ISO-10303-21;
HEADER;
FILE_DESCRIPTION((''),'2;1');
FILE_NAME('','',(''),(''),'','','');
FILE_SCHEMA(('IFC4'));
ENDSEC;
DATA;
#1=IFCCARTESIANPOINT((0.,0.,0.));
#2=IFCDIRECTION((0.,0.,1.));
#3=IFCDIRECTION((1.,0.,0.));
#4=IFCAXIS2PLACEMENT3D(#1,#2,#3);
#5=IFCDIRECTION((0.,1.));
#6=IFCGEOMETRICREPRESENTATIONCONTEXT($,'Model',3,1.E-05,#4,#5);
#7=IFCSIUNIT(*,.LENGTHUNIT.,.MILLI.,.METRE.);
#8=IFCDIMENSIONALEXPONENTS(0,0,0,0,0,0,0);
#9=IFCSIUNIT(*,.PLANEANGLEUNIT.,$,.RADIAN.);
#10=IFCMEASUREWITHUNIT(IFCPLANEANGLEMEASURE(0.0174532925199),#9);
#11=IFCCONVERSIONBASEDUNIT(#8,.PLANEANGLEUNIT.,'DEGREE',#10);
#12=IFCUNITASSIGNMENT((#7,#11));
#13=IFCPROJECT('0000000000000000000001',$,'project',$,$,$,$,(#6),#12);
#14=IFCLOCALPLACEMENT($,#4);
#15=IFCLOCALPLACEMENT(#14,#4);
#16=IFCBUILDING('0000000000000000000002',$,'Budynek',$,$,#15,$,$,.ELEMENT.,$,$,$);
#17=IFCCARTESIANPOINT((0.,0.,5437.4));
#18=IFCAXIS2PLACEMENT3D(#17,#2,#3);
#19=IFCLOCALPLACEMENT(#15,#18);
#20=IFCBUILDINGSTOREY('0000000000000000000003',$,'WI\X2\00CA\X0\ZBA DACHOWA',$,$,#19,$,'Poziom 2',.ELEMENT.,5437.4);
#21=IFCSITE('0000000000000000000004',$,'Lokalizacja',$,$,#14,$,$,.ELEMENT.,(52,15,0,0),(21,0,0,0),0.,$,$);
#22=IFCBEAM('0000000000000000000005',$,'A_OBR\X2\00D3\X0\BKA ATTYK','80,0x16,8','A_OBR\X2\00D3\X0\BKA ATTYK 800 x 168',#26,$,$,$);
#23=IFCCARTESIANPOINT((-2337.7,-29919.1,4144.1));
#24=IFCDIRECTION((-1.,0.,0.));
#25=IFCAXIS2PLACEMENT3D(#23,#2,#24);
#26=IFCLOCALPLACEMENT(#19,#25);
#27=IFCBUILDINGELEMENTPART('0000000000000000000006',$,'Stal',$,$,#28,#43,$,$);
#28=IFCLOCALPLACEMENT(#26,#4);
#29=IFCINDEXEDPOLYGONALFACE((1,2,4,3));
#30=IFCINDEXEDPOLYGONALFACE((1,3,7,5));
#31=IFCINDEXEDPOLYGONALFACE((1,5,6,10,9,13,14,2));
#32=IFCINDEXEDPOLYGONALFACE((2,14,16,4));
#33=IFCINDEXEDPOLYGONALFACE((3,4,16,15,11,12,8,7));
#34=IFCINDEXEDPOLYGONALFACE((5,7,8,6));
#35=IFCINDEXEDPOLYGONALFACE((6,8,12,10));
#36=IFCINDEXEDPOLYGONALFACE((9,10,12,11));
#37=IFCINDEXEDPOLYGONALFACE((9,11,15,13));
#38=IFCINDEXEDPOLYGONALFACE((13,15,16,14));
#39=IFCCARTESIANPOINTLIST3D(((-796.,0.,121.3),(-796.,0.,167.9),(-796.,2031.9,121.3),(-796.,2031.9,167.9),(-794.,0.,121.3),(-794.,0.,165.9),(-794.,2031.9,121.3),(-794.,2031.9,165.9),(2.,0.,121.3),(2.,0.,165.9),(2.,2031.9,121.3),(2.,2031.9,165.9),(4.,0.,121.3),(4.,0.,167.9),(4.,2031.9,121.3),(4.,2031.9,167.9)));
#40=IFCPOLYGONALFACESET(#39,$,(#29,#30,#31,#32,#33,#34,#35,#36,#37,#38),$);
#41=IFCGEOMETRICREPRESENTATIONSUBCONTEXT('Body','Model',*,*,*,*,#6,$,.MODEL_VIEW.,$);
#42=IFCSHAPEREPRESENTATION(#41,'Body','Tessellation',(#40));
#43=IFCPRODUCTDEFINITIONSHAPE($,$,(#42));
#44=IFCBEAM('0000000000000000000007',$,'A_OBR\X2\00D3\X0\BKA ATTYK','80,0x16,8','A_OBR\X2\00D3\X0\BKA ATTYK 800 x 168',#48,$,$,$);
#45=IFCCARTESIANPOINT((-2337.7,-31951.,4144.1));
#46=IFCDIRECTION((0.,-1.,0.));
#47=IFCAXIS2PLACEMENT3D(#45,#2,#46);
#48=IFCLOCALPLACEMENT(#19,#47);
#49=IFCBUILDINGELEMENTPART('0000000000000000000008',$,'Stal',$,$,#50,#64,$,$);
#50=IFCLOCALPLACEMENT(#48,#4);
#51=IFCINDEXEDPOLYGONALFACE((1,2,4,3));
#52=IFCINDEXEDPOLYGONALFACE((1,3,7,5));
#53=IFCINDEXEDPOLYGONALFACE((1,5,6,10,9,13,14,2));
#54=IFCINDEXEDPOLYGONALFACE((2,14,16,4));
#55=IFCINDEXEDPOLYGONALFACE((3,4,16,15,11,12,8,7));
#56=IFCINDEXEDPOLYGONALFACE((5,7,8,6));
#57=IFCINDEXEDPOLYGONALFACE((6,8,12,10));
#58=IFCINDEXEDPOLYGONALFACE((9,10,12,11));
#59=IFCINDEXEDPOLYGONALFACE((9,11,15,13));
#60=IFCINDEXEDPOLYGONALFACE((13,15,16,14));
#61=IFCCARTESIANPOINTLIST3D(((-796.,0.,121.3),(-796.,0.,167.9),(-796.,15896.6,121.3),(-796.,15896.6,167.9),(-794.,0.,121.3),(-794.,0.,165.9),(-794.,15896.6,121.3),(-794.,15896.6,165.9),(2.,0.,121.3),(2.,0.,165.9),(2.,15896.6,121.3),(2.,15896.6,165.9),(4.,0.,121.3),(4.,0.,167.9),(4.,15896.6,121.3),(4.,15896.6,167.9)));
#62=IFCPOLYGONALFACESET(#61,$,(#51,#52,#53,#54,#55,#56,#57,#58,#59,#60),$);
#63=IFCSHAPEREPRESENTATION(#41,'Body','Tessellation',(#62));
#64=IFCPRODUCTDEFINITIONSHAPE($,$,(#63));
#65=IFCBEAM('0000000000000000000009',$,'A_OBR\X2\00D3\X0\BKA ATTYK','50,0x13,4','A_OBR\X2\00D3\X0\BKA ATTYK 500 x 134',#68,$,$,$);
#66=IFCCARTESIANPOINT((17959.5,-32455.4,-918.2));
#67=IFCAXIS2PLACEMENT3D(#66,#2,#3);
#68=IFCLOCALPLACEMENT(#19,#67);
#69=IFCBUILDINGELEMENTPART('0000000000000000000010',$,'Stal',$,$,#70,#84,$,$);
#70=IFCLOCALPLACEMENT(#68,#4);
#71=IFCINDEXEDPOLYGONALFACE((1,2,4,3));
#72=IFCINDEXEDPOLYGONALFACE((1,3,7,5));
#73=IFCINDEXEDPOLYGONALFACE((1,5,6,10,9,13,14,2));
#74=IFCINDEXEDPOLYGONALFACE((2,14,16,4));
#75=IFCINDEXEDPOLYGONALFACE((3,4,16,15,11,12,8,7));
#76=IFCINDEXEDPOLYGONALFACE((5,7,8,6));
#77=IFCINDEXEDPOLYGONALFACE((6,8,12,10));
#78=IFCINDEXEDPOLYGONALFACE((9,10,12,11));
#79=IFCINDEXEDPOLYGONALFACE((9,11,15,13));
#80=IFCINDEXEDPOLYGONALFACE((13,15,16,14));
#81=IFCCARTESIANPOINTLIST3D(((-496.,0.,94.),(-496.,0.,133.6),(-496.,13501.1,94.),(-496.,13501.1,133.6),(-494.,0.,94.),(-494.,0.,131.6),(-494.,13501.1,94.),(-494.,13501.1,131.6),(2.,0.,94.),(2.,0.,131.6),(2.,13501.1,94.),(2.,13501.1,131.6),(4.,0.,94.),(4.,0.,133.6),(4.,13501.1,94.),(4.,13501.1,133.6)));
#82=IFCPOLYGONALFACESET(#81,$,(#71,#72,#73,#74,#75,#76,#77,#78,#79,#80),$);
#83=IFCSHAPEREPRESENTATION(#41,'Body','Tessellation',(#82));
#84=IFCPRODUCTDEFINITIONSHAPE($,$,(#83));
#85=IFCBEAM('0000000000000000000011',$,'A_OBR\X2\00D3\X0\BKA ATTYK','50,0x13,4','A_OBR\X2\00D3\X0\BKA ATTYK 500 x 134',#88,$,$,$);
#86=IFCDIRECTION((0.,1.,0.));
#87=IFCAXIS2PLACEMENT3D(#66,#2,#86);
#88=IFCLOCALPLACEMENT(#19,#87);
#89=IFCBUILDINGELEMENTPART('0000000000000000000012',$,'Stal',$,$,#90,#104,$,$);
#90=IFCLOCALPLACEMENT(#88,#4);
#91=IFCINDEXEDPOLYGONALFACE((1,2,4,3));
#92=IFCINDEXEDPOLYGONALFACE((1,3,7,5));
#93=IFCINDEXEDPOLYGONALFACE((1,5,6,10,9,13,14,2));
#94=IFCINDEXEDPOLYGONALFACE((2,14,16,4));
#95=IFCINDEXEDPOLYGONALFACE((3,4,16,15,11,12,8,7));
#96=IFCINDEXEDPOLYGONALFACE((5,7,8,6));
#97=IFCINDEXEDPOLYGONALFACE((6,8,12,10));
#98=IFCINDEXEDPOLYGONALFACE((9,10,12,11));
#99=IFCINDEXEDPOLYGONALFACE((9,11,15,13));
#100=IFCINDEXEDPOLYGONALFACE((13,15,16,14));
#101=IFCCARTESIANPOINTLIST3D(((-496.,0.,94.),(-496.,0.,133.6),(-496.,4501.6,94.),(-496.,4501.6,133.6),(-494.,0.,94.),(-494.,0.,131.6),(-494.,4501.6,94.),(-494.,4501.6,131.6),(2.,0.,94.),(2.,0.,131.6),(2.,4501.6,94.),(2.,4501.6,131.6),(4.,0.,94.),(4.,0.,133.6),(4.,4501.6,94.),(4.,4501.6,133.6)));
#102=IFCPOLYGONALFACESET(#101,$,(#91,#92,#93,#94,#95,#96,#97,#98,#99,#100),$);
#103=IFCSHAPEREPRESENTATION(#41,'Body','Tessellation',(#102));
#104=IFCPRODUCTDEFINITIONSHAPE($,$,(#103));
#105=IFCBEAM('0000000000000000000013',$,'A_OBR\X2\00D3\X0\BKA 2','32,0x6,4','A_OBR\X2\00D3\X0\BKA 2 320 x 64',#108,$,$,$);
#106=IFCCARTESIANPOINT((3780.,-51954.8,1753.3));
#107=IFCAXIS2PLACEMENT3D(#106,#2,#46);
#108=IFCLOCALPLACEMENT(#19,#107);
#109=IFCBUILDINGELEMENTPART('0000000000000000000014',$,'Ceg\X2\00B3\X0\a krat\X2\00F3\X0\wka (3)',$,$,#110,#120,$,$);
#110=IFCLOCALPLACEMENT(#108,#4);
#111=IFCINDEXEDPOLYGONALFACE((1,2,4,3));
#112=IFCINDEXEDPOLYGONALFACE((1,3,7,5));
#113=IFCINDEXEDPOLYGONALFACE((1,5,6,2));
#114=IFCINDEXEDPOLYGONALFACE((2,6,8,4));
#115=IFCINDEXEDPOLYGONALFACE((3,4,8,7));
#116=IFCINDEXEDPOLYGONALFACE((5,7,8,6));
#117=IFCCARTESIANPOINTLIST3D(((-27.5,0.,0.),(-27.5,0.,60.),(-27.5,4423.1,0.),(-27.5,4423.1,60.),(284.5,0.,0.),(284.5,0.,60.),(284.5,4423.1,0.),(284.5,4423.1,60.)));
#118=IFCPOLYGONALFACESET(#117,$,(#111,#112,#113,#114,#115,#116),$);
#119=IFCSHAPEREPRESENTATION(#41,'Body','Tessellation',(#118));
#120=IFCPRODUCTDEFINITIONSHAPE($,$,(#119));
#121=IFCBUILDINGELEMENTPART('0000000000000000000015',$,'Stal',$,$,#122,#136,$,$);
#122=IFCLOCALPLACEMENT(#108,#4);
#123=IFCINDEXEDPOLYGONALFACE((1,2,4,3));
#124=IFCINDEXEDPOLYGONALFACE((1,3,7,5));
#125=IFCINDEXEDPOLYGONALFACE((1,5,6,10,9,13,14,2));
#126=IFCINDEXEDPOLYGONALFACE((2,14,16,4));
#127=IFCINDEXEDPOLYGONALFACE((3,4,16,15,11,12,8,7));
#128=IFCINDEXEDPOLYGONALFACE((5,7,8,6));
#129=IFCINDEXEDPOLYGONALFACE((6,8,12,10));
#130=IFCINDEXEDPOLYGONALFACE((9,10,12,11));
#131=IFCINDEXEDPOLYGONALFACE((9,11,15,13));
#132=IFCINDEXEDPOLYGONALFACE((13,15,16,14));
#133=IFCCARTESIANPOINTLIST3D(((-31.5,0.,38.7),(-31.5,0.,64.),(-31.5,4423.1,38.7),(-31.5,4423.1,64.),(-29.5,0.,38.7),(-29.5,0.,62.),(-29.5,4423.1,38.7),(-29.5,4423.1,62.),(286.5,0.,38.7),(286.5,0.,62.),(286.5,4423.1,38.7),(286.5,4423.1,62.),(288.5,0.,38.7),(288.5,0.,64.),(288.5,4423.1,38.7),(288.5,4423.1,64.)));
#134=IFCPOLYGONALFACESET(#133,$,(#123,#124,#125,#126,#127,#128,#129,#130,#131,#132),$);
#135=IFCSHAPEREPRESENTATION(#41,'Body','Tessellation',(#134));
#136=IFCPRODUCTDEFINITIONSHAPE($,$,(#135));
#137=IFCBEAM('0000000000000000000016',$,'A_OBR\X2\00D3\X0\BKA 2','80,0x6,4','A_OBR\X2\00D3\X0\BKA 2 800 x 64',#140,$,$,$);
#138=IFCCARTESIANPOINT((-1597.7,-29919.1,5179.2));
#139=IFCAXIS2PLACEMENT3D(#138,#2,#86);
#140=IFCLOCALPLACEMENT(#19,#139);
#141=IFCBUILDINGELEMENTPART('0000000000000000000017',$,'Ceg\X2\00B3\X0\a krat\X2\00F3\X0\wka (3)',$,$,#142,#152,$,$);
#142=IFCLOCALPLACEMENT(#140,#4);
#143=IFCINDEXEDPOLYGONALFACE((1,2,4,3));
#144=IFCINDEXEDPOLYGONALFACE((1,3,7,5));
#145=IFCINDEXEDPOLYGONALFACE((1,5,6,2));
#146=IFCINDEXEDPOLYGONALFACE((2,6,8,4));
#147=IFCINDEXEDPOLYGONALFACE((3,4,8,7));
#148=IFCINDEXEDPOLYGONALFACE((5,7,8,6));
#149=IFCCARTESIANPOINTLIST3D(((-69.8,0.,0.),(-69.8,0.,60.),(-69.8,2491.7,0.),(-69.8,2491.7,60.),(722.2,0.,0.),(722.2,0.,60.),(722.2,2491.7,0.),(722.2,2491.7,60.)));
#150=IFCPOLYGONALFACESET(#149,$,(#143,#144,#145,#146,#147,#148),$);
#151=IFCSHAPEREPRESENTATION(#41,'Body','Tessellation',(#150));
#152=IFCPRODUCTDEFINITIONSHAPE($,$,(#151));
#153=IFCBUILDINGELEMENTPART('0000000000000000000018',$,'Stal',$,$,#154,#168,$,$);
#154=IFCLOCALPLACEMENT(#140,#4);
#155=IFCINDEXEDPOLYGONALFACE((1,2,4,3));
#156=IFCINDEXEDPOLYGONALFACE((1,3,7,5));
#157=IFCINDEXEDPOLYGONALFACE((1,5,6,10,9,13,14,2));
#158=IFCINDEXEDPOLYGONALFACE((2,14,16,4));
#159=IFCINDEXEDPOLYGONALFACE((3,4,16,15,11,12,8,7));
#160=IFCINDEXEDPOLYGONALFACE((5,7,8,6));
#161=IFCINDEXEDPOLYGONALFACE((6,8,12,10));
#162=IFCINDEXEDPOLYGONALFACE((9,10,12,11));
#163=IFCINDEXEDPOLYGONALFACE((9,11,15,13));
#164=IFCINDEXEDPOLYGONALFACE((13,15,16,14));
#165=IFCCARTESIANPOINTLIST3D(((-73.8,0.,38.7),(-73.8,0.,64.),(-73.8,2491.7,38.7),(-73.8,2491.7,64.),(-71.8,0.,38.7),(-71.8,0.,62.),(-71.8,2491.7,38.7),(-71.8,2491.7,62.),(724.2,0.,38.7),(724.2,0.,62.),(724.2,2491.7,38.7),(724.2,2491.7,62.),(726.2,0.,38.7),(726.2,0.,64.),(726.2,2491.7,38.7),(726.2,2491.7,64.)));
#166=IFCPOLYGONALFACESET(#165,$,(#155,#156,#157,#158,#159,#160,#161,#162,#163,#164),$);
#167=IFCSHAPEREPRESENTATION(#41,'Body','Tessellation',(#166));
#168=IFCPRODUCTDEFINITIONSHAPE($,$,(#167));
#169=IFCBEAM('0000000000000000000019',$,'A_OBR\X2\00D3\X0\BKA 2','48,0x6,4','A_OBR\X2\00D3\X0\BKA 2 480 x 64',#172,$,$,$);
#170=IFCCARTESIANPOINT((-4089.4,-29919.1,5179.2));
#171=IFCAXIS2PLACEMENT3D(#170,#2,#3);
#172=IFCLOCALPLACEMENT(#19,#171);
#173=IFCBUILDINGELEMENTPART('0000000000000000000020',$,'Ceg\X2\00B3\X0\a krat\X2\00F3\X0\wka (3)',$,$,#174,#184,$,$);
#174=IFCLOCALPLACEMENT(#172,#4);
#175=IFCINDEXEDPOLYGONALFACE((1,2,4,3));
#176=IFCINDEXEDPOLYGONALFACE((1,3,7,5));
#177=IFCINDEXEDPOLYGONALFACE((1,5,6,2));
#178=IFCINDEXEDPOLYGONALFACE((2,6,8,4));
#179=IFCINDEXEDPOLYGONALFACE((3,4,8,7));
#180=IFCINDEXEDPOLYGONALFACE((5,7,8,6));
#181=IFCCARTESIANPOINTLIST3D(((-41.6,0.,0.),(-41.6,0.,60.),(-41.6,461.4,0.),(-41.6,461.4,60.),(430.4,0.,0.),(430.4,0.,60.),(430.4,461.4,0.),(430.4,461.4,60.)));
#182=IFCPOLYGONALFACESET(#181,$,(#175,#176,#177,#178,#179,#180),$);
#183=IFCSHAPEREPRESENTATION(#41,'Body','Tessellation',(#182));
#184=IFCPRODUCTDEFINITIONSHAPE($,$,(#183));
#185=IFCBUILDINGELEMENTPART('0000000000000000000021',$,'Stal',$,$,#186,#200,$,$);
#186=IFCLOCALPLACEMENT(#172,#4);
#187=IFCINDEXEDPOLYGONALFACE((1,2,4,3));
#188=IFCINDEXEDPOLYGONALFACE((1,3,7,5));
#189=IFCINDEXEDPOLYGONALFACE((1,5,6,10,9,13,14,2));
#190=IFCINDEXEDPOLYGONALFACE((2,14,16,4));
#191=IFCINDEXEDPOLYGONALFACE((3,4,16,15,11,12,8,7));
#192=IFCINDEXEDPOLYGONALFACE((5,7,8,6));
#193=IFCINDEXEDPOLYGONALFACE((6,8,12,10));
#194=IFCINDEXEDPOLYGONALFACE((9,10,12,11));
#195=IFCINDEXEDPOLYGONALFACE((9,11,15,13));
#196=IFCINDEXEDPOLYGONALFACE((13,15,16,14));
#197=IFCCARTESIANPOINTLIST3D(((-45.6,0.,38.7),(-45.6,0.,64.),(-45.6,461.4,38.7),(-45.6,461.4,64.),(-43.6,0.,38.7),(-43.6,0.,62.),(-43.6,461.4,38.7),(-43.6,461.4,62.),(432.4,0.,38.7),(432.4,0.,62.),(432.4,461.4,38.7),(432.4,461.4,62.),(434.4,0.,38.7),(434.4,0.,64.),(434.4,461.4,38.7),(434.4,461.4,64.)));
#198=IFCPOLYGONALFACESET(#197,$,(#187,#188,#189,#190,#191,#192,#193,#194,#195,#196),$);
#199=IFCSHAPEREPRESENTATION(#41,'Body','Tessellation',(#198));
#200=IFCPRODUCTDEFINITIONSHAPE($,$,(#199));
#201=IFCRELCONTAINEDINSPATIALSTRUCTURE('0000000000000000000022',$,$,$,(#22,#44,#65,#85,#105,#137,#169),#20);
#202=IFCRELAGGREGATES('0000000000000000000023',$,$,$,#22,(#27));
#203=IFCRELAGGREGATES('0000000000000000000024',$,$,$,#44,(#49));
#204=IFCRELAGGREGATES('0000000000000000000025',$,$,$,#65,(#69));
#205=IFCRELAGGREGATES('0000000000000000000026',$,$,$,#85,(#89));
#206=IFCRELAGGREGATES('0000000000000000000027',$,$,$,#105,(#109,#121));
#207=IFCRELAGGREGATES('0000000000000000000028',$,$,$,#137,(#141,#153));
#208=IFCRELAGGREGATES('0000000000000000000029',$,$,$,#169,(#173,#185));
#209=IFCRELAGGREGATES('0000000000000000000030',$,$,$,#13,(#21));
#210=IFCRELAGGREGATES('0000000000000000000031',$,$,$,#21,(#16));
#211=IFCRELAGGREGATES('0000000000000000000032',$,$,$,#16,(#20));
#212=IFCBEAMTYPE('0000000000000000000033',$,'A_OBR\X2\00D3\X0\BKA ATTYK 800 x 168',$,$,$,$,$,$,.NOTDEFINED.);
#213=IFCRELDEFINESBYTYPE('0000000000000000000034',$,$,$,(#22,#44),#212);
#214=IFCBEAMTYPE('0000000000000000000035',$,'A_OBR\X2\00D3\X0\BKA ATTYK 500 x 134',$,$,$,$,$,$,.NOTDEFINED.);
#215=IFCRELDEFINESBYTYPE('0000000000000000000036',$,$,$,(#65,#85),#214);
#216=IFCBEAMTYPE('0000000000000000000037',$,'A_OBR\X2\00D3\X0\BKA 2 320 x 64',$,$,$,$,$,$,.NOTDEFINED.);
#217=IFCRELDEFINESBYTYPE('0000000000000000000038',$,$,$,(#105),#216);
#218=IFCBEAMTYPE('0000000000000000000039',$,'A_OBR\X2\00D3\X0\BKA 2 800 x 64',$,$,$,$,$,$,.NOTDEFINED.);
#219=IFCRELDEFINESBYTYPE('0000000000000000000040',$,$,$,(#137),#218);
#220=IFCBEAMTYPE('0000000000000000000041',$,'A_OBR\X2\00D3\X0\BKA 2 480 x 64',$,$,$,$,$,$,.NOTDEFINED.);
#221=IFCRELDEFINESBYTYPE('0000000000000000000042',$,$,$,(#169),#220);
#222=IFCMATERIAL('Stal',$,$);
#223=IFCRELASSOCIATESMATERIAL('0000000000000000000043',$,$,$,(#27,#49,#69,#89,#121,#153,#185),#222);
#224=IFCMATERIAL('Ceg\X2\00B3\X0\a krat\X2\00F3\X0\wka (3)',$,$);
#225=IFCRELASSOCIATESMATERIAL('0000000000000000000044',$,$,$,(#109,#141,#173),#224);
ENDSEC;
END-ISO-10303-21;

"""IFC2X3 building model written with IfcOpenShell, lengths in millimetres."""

from ifc_helpers import new_model, entity, si_unit, converted_unit, direction, frame, origin_with_axes, place, context, subcontext, project, spatial, polyline, outline, extrude, material, type_object, element, aggregate, save


model = new_model("IFC2X3")

# Units and contexts
model_context = context("Model", 3, precision=1e-05, world=origin_with_axes(), true_north=direction((0.0, 1.0)))
body_context = subcontext(model_context, "Body", "Model", "MODEL_VIEW")
ifc_project = project(units=[si_unit("LENGTHUNIT", "METRE", prefix="MILLI"), converted_unit("PLANEANGLEUNIT", "DEGREE", entity("IfcPlaneAngleMeasure", 0.0174532925199), si_unit("PLANEANGLEUNIT", "RADIAN"), dimensions=[0, 0, 0, 0, 0, 0, 0])], contexts=[model_context])

# Site, building, storey
site_placement = place(None, origin_with_axes())
site = spatial("IfcSite", under=ifc_project, at=site_placement, Name="Lokalizacja", CompositionType="ELEMENT", RefLatitude=(52, 15, 0, 0), RefLongitude=(21, 0, 0, 0), RefElevation=0.0)
building_placement = place(site_placement, origin_with_axes())
building = spatial("IfcBuilding", under=site, at=building_placement, Name="Budynek", CompositionType="ELEMENT")
storey_placement = place(building_placement, frame((0.0, 0.0, 5437.4), z_axis=(0.0, 0.0, 1.0), x_axis=(1.0, 0.0, 0.0)))
storey = spatial("IfcBuildingStorey", under=building, at=storey_placement, Name="WIÊZBA DACHOWA", LongName="Poziom 2", CompositionType="ELEMENT", Elevation=5437.4)

# Shared definitions
ifc_material_1 = material(Name="Ceg³a kratówka (3)")

# Beams, building element parts
beam_type_1 = type_object("IfcBeamType", Name="A_OBRÓBKA ATTYK 800 x 168", PredefinedType="NOTDEFINED")
beam_1_placement = place(storey_placement, frame((-2337.7, -29919.1, 4144.1), z_axis=(0.0, 0.0, 1.0), x_axis=(-1.0, 0.0, 0.0)))
beam_1 = element("IfcBeam", 1, at=beam_1_placement, inside=storey, type_object=beam_type_1, Name="A_OBRÓBKA ATTYK", Description="80,0x16,8", ObjectType="A_OBRÓBKA ATTYK 800 x 168")
ifc_material_2 = material(Name="Stal")
building_element_part_1_placement = place(beam_1_placement, origin_with_axes())
building_element_part_1 = element("IfcBuildingElementPart", 2, at=building_element_part_1_placement, material=ifc_material_2, Name="Stal", context=body_context, shape_type="SweptSolid", body=[
    extrude(outline(polyline([(-796.0, 167.9), (-796.0, 121.3), (-794.0, 121.3), (-794.0, 165.9), (2.0, 165.9), (2.0, 121.3), (4.0, 121.3), (4.0, 167.9), (-796.0, 167.9)])), frame((0.0, 2031.9, 0.0), z_axis=(0.0, -1.0, 0.0), x_axis=(1.0, 0.0, 0.0)), (0.0, 0.0, 1.0), 2031.9),
])
aggregate(beam_1, [building_element_part_1])
beam_2_placement = place(storey_placement, frame((-2337.7, -31951.0, 4144.1), z_axis=(0.0, 0.0, 1.0), x_axis=(0.0, -1.0, 0.0)))
beam_2 = element("IfcBeam", 3, at=beam_2_placement, inside=storey, type_object=beam_type_1, Name="A_OBRÓBKA ATTYK", Description="80,0x16,8", ObjectType="A_OBRÓBKA ATTYK 800 x 168")
building_element_part_2_placement = place(beam_2_placement, origin_with_axes())
building_element_part_2 = element("IfcBuildingElementPart", 4, at=building_element_part_2_placement, material=ifc_material_2, Name="Stal", context=body_context, shape_type="SweptSolid", body=[
    extrude(outline(polyline([(-796.0, 167.9), (-796.0, 121.3), (-794.0, 121.3), (-794.0, 165.9), (2.0, 165.9), (2.0, 121.3), (4.0, 121.3), (4.0, 167.9), (-796.0, 167.9)])), frame((0.0, 15896.6, 0.0), z_axis=(0.0, -1.0, 0.0), x_axis=(1.0, 0.0, 0.0)), (0.0, 0.0, 1.0), 15896.6),
])
aggregate(beam_2, [building_element_part_2])
beam_type_2 = type_object("IfcBeamType", Name="A_OBRÓBKA ATTYK 500 x 134", PredefinedType="NOTDEFINED")
beam_3_placement = place(storey_placement, frame((17959.5, -32455.4, -918.2), z_axis=(0.0, 0.0, 1.0), x_axis=(1.0, 0.0, 0.0)))
beam_3 = element("IfcBeam", 5, at=beam_3_placement, inside=storey, type_object=beam_type_2, Name="A_OBRÓBKA ATTYK", Description="50,0x13,4", ObjectType="A_OBRÓBKA ATTYK 500 x 134")
building_element_part_3_placement = place(beam_3_placement, origin_with_axes())
building_element_part_3 = element("IfcBuildingElementPart", 6, at=building_element_part_3_placement, material=ifc_material_2, Name="Stal", context=body_context, shape_type="SweptSolid", body=[
    extrude(outline(polyline([(-496.0, 133.6), (-496.0, 94.0), (-494.0, 94.0), (-494.0, 131.6), (2.0, 131.6), (2.0, 94.0), (4.0, 94.0), (4.0, 133.6), (-496.0, 133.6)])), frame((0.0, 13501.1, 0.0), z_axis=(0.0, -1.0, 0.0), x_axis=(1.0, 0.0, 0.0)), (0.0, 0.0, 1.0), 13501.1),
])
aggregate(beam_3, [building_element_part_3])
beam_4_placement = place(storey_placement, frame((17959.5, -32455.4, -918.2), z_axis=(0.0, 0.0, 1.0), x_axis=(0.0, 1.0, 0.0)))
beam_4 = element("IfcBeam", 7, at=beam_4_placement, inside=storey, type_object=beam_type_2, Name="A_OBRÓBKA ATTYK", Description="50,0x13,4", ObjectType="A_OBRÓBKA ATTYK 500 x 134")
building_element_part_4_placement = place(beam_4_placement, origin_with_axes())
building_element_part_4 = element("IfcBuildingElementPart", 8, at=building_element_part_4_placement, material=ifc_material_2, Name="Stal", context=body_context, shape_type="SweptSolid", body=[
    extrude(outline(polyline([(-496.0, 133.6), (-496.0, 94.0), (-494.0, 94.0), (-494.0, 131.6), (2.0, 131.6), (2.0, 94.0), (4.0, 94.0), (4.0, 133.6), (-496.0, 133.6)])), frame((0.0, 4501.6, 0.0), z_axis=(0.0, -1.0, 0.0), x_axis=(1.0, 0.0, 0.0)), (0.0, 0.0, 1.0), 4501.6),
])
aggregate(beam_4, [building_element_part_4])
beam_type_3 = type_object("IfcBeamType", Name="A_OBRÓBKA 2 320 x 64", PredefinedType="NOTDEFINED")
beam_5_placement = place(storey_placement, frame((3780.0, -51954.8, 1753.3), z_axis=(0.0, 0.0, 1.0), x_axis=(0.0, -1.0, 0.0)))
beam_5 = element("IfcBeam", 9, at=beam_5_placement, inside=storey, type_object=beam_type_3, Name="A_OBRÓBKA 2", Description="32,0x6,4", ObjectType="A_OBRÓBKA 2 320 x 64")
building_element_part_5_placement = place(beam_5_placement, origin_with_axes())
building_element_part_5 = element("IfcBuildingElementPart", 10, at=building_element_part_5_placement, material=ifc_material_1, Name="Ceg³a kratówka (3)", context=body_context, shape_type="SweptSolid", body=[
    extrude(outline(polyline([(284.5, 0.0), (284.5, 60.0), (-27.5, 60.0), (-27.5, 0.0), (284.5, 0.0)])), frame((0.0, 4423.1, 0.0), z_axis=(0.0, -1.0, 0.0), x_axis=(1.0, 0.0, 0.0)), (0.0, 0.0, 1.0), 4423.1),
])
building_element_part_6_placement = place(beam_5_placement, origin_with_axes())
building_element_part_6 = element("IfcBuildingElementPart", 11, at=building_element_part_6_placement, material=ifc_material_2, Name="Stal", context=body_context, shape_type="SweptSolid", body=[
    extrude(outline(polyline([(-31.5, 64.0), (-31.5, 38.7), (-29.5, 38.7), (-29.5, 62.0), (286.5, 62.0), (286.5, 38.7), (288.5, 38.7), (288.5, 64.0), (-31.5, 64.0)])), frame((0.0, 4423.1, 0.0), z_axis=(0.0, -1.0, 0.0), x_axis=(1.0, 0.0, 0.0)), (0.0, 0.0, 1.0), 4423.1),
])
aggregate(beam_5, [building_element_part_5, building_element_part_6])
beam_type_4 = type_object("IfcBeamType", Name="A_OBRÓBKA 2 800 x 64", PredefinedType="NOTDEFINED")
beam_6_placement = place(storey_placement, frame((-1597.7, -29919.1, 5179.2), z_axis=(0.0, 0.0, 1.0), x_axis=(0.0, 1.0, 0.0)))
beam_6 = element("IfcBeam", 12, at=beam_6_placement, inside=storey, type_object=beam_type_4, Name="A_OBRÓBKA 2", Description="80,0x6,4", ObjectType="A_OBRÓBKA 2 800 x 64")
building_element_part_7_placement = place(beam_6_placement, origin_with_axes())
building_element_part_7 = element("IfcBuildingElementPart", 13, at=building_element_part_7_placement, material=ifc_material_1, Name="Ceg³a kratówka (3)", context=body_context, shape_type="SweptSolid", body=[
    extrude(outline(polyline([(722.2, 0.0), (722.2, 60.0), (-69.8, 60.0), (-69.8, 0.0), (722.2, 0.0)])), frame((0.0, 2491.7, 0.0), z_axis=(0.0, -1.0, 0.0), x_axis=(1.0, 0.0, 0.0)), (0.0, 0.0, 1.0), 2491.7),
])
building_element_part_8_placement = place(beam_6_placement, origin_with_axes())
building_element_part_8 = element("IfcBuildingElementPart", 14, at=building_element_part_8_placement, material=ifc_material_2, Name="Stal", context=body_context, shape_type="SweptSolid", body=[
    extrude(outline(polyline([(-73.8, 64.0), (-73.8, 38.7), (-71.8, 38.7), (-71.8, 62.0), (724.2, 62.0), (724.2, 38.7), (726.2, 38.7), (726.2, 64.0), (-73.8, 64.0)])), frame((0.0, 2491.7, 0.0), z_axis=(0.0, -1.0, 0.0), x_axis=(1.0, 0.0, 0.0)), (0.0, 0.0, 1.0), 2491.7),
])
aggregate(beam_6, [building_element_part_7, building_element_part_8])
beam_type_5 = type_object("IfcBeamType", Name="A_OBRÓBKA 2 480 x 64", PredefinedType="NOTDEFINED")
beam_7_placement = place(storey_placement, frame((-4089.4, -29919.1, 5179.2), z_axis=(0.0, 0.0, 1.0), x_axis=(1.0, 0.0, 0.0)))
beam_7 = element("IfcBeam", 15, at=beam_7_placement, inside=storey, type_object=beam_type_5, Name="A_OBRÓBKA 2", Description="48,0x6,4", ObjectType="A_OBRÓBKA 2 480 x 64")
building_element_part_9_placement = place(beam_7_placement, origin_with_axes())
building_element_part_9 = element("IfcBuildingElementPart", 16, at=building_element_part_9_placement, material=ifc_material_1, Name="Ceg³a kratówka (3)", context=body_context, shape_type="SweptSolid", body=[
    extrude(outline(polyline([(430.4, 0.0), (430.4, 60.0), (-41.6, 60.0), (-41.6, 0.0), (430.4, 0.0)])), frame((0.0, 461.4, 0.0), z_axis=(0.0, -1.0, 0.0), x_axis=(1.0, 0.0, 0.0)), (0.0, 0.0, 1.0), 461.4),
])
building_element_part_10_placement = place(beam_7_placement, origin_with_axes())
building_element_part_10 = element("IfcBuildingElementPart", 17, at=building_element_part_10_placement, material=ifc_material_2, Name="Stal", context=body_context, shape_type="SweptSolid", body=[
    extrude(outline(polyline([(-45.6, 64.0), (-45.6, 38.7), (-43.6, 38.7), (-43.6, 62.0), (432.4, 62.0), (432.4, 38.7), (434.4, 38.7), (434.4, 64.0), (-45.6, 64.0)])), frame((0.0, 461.4, 0.0), z_axis=(0.0, -1.0, 0.0), x_axis=(1.0, 0.0, 0.0)), (0.0, 0.0, 1.0), 461.4),
])
aggregate(beam_7, [building_element_part_9, building_element_part_10])

save(model, "model.ifc")
